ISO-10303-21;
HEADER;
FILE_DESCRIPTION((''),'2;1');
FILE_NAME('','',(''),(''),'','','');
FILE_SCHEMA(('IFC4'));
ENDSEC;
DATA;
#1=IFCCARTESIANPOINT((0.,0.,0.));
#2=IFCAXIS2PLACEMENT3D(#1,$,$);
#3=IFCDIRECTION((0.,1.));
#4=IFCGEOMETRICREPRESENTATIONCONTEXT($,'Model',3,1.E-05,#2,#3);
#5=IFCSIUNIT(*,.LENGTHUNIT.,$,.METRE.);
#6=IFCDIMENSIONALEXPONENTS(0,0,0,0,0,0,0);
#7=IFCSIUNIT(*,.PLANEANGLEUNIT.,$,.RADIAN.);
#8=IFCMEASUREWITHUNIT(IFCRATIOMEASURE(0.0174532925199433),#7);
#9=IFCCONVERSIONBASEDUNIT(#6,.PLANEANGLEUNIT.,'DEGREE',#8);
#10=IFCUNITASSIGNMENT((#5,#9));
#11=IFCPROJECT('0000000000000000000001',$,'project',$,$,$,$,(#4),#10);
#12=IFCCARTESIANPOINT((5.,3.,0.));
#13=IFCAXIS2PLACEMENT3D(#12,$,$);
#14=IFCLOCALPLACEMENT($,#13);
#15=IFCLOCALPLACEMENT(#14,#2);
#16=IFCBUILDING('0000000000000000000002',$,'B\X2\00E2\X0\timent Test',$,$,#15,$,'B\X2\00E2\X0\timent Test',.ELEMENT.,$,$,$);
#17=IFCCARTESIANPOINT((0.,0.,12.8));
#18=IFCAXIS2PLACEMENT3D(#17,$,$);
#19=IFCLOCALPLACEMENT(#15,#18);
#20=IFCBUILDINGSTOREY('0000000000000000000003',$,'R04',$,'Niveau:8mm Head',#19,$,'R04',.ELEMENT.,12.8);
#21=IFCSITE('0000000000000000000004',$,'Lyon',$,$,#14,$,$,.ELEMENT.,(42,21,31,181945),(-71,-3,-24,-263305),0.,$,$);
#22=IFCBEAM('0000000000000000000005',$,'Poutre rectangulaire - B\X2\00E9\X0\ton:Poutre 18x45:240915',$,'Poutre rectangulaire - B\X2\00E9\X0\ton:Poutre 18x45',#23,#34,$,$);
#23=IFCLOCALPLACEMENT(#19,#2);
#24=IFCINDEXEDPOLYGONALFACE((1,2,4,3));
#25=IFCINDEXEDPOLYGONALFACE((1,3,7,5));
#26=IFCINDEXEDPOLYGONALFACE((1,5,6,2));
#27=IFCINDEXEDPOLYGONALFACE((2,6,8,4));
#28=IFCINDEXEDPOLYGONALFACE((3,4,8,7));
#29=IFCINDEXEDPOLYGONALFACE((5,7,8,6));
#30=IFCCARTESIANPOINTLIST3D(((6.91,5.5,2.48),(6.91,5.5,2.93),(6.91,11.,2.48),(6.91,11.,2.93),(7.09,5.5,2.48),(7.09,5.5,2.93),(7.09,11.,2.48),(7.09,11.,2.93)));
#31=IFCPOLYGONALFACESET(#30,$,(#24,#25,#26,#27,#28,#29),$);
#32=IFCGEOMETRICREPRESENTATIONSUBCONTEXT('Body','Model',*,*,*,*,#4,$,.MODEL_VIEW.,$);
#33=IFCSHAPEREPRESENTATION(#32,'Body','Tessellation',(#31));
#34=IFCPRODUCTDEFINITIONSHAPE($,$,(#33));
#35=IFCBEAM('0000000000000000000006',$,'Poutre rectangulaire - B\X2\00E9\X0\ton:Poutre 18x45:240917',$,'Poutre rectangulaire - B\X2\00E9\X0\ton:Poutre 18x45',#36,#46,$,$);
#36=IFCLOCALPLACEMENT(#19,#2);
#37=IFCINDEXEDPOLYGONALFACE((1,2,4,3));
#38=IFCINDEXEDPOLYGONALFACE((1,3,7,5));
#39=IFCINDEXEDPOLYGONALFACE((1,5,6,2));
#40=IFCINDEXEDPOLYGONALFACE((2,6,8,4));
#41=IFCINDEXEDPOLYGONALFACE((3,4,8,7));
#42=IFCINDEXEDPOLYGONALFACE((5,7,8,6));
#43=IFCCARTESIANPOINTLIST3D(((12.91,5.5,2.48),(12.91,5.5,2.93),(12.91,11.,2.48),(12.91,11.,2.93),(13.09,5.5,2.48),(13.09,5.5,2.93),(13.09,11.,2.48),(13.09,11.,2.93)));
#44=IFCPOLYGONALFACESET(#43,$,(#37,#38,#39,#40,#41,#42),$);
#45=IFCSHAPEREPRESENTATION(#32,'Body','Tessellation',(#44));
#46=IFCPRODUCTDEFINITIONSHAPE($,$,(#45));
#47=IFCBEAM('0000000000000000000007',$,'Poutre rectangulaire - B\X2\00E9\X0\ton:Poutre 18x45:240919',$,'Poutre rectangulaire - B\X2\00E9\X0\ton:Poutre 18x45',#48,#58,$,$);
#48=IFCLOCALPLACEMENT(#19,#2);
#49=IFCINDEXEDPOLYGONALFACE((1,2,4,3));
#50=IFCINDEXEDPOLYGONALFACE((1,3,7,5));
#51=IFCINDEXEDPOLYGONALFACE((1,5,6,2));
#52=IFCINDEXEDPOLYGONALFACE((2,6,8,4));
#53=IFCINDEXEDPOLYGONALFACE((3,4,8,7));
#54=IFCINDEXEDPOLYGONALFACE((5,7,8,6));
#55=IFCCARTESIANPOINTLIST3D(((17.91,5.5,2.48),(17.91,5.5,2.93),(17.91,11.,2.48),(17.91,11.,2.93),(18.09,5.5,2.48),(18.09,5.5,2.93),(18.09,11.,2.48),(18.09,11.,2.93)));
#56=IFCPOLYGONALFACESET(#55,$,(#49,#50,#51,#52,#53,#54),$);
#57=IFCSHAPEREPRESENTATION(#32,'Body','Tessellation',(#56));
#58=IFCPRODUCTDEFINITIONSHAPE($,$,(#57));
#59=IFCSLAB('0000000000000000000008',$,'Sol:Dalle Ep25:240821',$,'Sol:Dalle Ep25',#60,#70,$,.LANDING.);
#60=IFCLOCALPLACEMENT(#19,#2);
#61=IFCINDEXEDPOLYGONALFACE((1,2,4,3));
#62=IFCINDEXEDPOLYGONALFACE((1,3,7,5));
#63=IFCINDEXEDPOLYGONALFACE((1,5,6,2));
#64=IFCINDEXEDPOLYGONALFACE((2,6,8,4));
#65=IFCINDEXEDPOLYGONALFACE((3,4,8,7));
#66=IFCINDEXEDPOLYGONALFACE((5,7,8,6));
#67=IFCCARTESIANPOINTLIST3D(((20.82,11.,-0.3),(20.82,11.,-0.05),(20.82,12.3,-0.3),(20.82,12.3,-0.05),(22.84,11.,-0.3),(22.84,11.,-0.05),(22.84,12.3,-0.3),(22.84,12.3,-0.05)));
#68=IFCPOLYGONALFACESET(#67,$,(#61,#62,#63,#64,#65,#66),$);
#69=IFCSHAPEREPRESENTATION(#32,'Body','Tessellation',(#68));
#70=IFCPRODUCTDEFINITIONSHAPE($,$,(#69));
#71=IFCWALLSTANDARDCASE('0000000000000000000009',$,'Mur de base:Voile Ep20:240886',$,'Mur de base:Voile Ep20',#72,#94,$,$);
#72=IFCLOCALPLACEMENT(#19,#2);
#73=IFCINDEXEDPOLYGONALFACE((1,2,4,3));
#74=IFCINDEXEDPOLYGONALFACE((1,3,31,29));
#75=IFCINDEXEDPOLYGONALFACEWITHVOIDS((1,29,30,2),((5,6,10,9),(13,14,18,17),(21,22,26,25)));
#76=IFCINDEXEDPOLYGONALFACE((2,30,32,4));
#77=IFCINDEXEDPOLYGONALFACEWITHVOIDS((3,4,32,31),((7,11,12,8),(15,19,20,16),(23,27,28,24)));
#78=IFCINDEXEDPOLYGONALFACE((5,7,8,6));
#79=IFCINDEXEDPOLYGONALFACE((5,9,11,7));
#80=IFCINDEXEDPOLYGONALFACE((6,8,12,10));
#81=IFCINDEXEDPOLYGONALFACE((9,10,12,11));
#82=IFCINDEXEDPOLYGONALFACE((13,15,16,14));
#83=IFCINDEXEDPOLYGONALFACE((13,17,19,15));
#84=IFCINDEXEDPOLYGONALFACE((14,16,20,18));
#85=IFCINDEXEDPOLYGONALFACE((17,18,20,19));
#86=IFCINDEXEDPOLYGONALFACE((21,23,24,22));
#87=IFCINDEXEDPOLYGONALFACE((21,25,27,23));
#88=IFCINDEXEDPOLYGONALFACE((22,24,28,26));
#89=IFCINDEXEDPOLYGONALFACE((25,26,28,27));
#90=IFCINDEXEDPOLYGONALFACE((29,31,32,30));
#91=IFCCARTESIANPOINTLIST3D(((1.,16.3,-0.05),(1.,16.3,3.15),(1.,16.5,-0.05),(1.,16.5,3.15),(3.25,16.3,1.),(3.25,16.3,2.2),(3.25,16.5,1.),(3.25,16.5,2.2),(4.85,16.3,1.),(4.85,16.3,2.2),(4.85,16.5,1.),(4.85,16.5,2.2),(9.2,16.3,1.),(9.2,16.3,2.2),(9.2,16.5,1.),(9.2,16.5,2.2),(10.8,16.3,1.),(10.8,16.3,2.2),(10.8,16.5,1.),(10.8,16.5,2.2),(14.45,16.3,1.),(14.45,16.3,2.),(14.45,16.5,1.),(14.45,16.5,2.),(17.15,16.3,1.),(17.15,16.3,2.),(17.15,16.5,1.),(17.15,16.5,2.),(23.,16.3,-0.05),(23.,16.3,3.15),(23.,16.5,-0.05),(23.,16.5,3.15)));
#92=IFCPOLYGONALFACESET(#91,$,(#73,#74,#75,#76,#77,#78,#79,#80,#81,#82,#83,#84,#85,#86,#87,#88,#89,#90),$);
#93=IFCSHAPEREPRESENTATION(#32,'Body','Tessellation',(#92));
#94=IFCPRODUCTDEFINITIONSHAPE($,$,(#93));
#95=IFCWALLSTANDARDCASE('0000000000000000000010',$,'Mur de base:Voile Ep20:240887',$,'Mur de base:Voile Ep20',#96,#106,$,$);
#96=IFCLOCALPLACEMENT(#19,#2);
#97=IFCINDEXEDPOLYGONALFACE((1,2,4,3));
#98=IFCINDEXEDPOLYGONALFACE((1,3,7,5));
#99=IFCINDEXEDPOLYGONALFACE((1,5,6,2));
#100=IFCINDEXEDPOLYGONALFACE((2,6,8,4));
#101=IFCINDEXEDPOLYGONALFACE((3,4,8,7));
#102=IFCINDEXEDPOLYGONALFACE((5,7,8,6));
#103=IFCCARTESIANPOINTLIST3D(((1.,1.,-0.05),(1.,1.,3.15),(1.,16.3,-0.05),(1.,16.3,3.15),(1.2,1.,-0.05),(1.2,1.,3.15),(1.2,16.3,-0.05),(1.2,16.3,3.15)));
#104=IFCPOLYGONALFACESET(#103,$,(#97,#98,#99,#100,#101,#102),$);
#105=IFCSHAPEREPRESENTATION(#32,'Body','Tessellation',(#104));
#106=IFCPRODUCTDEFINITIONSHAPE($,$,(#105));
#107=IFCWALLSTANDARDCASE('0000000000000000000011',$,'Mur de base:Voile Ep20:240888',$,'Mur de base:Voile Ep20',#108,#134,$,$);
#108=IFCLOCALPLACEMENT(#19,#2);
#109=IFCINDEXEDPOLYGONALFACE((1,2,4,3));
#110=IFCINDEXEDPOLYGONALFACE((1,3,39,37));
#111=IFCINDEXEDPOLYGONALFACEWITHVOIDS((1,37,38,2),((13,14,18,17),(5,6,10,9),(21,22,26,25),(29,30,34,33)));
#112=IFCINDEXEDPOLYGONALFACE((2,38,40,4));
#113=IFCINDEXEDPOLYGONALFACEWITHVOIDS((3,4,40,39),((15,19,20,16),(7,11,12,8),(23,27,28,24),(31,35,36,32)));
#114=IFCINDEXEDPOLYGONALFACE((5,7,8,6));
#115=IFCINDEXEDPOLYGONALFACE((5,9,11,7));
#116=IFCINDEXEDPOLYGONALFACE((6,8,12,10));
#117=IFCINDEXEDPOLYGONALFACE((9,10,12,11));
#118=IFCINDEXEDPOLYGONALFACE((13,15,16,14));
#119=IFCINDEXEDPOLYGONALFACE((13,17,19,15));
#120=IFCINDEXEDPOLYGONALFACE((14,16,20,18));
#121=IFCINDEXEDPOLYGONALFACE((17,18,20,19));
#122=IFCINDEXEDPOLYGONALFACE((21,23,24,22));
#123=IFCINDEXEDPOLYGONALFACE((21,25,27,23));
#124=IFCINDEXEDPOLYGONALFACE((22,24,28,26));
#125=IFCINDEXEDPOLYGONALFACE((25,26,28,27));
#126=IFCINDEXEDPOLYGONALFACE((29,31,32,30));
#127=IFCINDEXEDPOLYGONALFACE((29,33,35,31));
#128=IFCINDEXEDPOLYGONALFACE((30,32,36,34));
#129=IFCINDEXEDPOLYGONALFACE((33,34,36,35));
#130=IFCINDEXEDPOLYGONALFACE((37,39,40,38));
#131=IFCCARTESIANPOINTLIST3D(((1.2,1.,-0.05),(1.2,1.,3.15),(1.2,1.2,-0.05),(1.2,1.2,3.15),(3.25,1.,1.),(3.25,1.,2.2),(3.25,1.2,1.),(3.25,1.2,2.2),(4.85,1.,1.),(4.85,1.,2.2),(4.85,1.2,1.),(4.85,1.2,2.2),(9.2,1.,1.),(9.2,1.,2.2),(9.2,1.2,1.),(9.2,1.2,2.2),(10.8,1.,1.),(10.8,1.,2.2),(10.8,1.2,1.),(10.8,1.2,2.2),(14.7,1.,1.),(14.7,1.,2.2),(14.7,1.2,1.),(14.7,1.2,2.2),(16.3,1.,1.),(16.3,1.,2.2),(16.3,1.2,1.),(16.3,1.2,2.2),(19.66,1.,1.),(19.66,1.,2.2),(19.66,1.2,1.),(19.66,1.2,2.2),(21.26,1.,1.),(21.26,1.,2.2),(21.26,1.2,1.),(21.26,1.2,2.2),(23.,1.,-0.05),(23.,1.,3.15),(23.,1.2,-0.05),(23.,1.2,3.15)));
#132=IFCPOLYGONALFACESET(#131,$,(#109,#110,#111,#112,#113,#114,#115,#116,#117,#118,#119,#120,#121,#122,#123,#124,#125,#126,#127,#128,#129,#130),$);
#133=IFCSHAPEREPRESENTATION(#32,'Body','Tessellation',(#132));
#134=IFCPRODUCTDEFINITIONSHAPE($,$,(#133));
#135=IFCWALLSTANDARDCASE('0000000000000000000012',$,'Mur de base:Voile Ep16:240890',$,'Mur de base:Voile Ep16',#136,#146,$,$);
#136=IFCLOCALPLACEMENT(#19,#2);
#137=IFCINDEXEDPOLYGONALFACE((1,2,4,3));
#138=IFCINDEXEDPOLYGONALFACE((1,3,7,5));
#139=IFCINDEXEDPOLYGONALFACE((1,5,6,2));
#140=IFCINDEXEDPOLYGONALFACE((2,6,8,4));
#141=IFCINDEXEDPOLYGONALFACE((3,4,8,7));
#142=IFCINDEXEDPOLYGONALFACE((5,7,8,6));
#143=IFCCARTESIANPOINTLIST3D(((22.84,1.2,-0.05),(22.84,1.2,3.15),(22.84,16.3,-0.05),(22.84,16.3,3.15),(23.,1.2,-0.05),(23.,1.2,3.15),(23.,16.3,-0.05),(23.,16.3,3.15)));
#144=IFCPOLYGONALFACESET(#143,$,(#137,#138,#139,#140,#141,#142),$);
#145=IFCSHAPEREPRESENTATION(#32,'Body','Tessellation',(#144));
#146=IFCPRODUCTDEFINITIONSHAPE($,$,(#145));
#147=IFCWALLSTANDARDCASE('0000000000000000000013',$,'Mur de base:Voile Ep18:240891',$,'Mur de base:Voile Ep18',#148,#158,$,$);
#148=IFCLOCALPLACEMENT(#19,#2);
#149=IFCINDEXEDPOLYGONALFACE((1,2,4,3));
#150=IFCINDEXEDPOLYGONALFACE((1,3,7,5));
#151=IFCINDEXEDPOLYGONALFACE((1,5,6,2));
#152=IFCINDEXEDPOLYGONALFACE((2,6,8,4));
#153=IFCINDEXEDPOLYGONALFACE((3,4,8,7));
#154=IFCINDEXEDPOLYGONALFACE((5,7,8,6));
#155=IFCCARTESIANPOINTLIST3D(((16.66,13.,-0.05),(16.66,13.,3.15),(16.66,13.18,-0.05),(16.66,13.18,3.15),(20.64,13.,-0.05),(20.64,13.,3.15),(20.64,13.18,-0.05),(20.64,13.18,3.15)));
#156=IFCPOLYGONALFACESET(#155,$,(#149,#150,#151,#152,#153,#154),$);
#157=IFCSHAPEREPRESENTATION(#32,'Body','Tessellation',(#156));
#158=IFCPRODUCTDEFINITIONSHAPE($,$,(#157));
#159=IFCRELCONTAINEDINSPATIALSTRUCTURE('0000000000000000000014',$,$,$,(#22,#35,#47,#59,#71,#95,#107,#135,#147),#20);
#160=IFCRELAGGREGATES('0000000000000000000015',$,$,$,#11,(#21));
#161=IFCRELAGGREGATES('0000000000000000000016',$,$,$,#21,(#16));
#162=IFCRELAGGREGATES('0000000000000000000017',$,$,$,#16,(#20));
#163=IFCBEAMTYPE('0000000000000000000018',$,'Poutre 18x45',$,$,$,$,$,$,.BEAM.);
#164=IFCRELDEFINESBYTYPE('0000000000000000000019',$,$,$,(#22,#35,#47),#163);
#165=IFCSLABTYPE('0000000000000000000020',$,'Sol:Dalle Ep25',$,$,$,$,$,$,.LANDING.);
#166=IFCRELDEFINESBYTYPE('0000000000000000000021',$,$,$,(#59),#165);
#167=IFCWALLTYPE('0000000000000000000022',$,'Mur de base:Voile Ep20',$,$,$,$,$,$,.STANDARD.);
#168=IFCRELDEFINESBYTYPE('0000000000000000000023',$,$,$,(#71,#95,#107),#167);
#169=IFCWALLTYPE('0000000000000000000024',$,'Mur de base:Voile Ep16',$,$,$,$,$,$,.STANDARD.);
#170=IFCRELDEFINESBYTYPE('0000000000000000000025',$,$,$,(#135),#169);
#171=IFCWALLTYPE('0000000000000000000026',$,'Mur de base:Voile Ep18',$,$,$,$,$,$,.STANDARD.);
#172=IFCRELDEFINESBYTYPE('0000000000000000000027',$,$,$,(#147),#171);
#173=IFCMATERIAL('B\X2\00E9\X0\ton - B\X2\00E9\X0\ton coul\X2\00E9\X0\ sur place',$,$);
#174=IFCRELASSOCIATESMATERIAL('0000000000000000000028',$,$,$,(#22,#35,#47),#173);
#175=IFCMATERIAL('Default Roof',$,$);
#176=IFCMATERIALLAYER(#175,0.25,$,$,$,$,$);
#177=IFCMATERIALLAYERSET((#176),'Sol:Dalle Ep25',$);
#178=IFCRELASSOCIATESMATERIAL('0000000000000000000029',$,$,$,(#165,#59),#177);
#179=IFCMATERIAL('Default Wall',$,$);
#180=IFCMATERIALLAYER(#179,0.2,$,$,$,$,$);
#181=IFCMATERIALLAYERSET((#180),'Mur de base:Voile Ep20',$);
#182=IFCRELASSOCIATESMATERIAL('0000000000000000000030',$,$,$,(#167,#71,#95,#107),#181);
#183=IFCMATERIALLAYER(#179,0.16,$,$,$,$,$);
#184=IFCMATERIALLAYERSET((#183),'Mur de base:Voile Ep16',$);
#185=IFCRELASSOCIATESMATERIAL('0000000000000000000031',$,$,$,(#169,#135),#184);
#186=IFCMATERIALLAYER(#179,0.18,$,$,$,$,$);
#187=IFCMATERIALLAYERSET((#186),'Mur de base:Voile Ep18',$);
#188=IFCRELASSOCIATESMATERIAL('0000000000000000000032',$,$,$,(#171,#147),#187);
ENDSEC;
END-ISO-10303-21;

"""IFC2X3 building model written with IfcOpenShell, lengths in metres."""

from ifc_helpers import new_model, entity, si_unit, converted_unit, direction, frame, frame_2d, origin, origin_2d_with_axis, place, context, subcontext, project, spatial, rectangle, extrude, material, layer, layer_set, layer_usage, type_object, element, save


model = new_model("IFC2X3")

# Units and contexts
model_context = context("Model", 3, precision=1e-05, world=origin(), true_north=direction((0.0, 1.0)))
body_context = subcontext(model_context, "Body", "Model", "MODEL_VIEW")
ifc_project = project(units=[si_unit("LENGTHUNIT", "METRE"), converted_unit("PLANEANGLEUNIT", "DEGREE", entity("IfcRatioMeasure", 0.0174532925199433), si_unit("PLANEANGLEUNIT", "RADIAN"), dimensions=[0, 0, 0, 0, 0, 0, 0])], contexts=[model_context])

# Site, building, storey
site_placement = place(None, frame((5.0, 3.0, 0.0)))
site = spatial("IfcSite", under=ifc_project, at=site_placement, Name="Lyon", CompositionType="ELEMENT", RefLatitude=(42, 21, 31, 181945), RefLongitude=(-71, -3, -24, -263305), RefElevation=0.0)
building_placement = place(site_placement, origin())
building = spatial("IfcBuilding", under=site, at=building_placement, Name="Bâtiment Test", LongName="Bâtiment Test", CompositionType="ELEMENT")
storey_placement = place(building_placement, frame((0.0, 0.0, 12.8)))
storey = spatial("IfcBuildingStorey", under=building, at=storey_placement, Name="R04", ObjectType="Niveau:8mm Head", LongName="R04", CompositionType="ELEMENT", Elevation=12.8)

# Beams
ifc_material_1 = material(Name="Béton - Béton coulé sur place")
beam_type = type_object("IfcBeamType", Name="Poutre 18x45", PredefinedType="BEAM")
beam_1_placement = place(storey_placement, frame((7.0, 11.0, 2.93), z_axis=(0.0, 0.0, 1.0), x_axis=(0.0, -1.0, 0.0)))
element("IfcBeam", 1, at=beam_1_placement, inside=storey, type_object=beam_type, material=ifc_material_1, Name="Poutre rectangulaire - Béton:Poutre 18x45:240915", ObjectType="Poutre rectangulaire - Béton:Poutre 18x45", context=body_context, shape_type="SweptSolid", body=[
    extrude(rectangle(XDim=0.45, YDim=0.18, at=frame_2d((0.0, 0.0), x_axis=(1.0, 0.0))), frame((0.0, 0.0, -0.225), z_axis=(1.0, 0.0, 0.0), x_axis=(0.0, 0.0, -1.0)), (0.0, 0.0, 1.0), 5.5),
])
beam_2_placement = place(storey_placement, frame((13.0, 11.0, 2.93), z_axis=(0.0, 0.0, 1.0), x_axis=(0.0, -1.0, 0.0)))
element("IfcBeam", 2, at=beam_2_placement, inside=storey, type_object=beam_type, material=ifc_material_1, Name="Poutre rectangulaire - Béton:Poutre 18x45:240917", ObjectType="Poutre rectangulaire - Béton:Poutre 18x45", context=body_context, shape_type="SweptSolid", body=[
    extrude(rectangle(XDim=0.45, YDim=0.18, at=frame_2d((0.0, 0.0), x_axis=(1.0, 0.0))), frame((0.0, 0.0, -0.225), z_axis=(1.0, 0.0, 0.0), x_axis=(0.0, 0.0, -1.0)), (0.0, 0.0, 1.0), 5.5),
])
beam_3_placement = place(storey_placement, frame((18.0, 5.5, 2.93), z_axis=(0.0, 0.0, 1.0), x_axis=(0.0, 1.0, 0.0)))
element("IfcBeam", 3, at=beam_3_placement, inside=storey, type_object=beam_type, material=ifc_material_1, Name="Poutre rectangulaire - Béton:Poutre 18x45:240919", ObjectType="Poutre rectangulaire - Béton:Poutre 18x45", context=body_context, shape_type="SweptSolid", body=[
    extrude(rectangle(XDim=0.45, YDim=0.18, at=frame_2d((0.0, 0.0), x_axis=(1.0, 0.0))), frame((0.0, 0.0, -0.225), z_axis=(1.0, 0.0, 0.0), x_axis=(0.0, 0.0, -1.0)), (0.0, 0.0, 1.0), 5.5),
])

# Slab
ifc_material_2 = material(Name="Default Roof")
ifc_layer_1 = layer(ifc_material_2, 0.25)
ifc_layer_set_1 = layer_set([ifc_layer_1], Name="Sol:Dalle Ep25")
ifc_layer_usage_1 = layer_usage(ifc_layer_set_1, "AXIS3", "POSITIVE", 0.0)
slab_type_1 = type_object("IfcSlabType", Name="Sol:Dalle Ep25", PredefinedType="LANDING", material=ifc_layer_set_1)
slab_1_placement = place(storey_placement, origin())
element("IfcSlab", 4, at=slab_1_placement, inside=storey, type_object=slab_type_1, material=ifc_layer_usage_1, Name="Sol:Dalle Ep25:240821", ObjectType="Sol:Dalle Ep25", PredefinedType="LANDING", context=body_context, shape_type="SweptSolid", body=[
    extrude(rectangle(XDim=1.3, YDim=2.02, at=frame_2d((0.0, 0.0), x_axis=(1.0, 0.0))), frame((21.83, 11.65, -0.05), z_axis=(0.0, 0.0, -1.0), x_axis=(0.0, 1.0, 0.0)), (0.0, 0.0, 1.0), 0.25),
])

# Wall, openings
ifc_material_3 = material(Name="Default Wall")
ifc_layer_2 = layer(ifc_material_3, 0.2)
ifc_layer_set_2 = layer_set([ifc_layer_2], Name="Mur de base:Voile Ep20")
ifc_layer_usage_2 = layer_usage(ifc_layer_set_2, "AXIS2", "POSITIVE", -0.1)
wall_type_1 = type_object("IfcWallType", Name="Mur de base:Voile Ep20", PredefinedType="STANDARD", material=ifc_layer_set_2)
wall_1_placement = place(storey_placement, frame((23.0, 16.4, -0.05), z_axis=(0.0, 0.0, 1.0), x_axis=(-1.0, 0.0, 0.0)))
wall_1 = element("IfcWallStandardCase", 5, at=wall_1_placement, inside=storey, type_object=wall_type_1, material=ifc_layer_usage_2, Name="Mur de base:Voile Ep20:240886", ObjectType="Mur de base:Voile Ep20", context=body_context, shape_type="SweptSolid", body=[
    extrude(rectangle(XDim=22.0, YDim=0.2, at=frame_2d((11.0, 0.0), x_axis=(-1.0, 0.0))), origin(), (0.0, 0.0, 1.0), 3.2),
])
opening_1_placement = place(wall_1_placement, origin())
element("IfcOpeningElement", 6, at=opening_1_placement, cuts=wall_1, ObjectType="Opening", context=body_context, shape_type="SweptSolid", body=[
    extrude(rectangle(XDim=1.0, YDim=2.7, at=origin_2d_with_axis()), frame((7.2, -0.1, 1.55), z_axis=(0.0, 1.0, 0.0), x_axis=(0.0, 0.0, -1.0)), (0.0, 0.0, 1.0), 0.2),
])
opening_2_placement = place(wall_1_placement, origin())
element("IfcOpeningElement", 7, at=opening_2_placement, cuts=wall_1, ObjectType="Opening", context=body_context, shape_type="SweptSolid", body=[
    extrude(rectangle(XDim=1.2, YDim=1.6, at=frame_2d((0.0, 0.0), x_axis=(1.0, 0.0))), frame((13.0, -0.1, 1.65), z_axis=(0.0, 1.0, 0.0), x_axis=(0.0, 0.0, -1.0)), (0.0, 0.0, 1.0), 0.2),
])
opening_3_placement = place(wall_1_placement, origin())
element("IfcOpeningElement", 8, at=opening_3_placement, cuts=wall_1, ObjectType="Opening", context=body_context, shape_type="SweptSolid", body=[
    extrude(rectangle(XDim=1.2, YDim=1.6, at=frame_2d((0.0, 0.0), x_axis=(1.0, 0.0))), frame((18.95, -0.1, 1.65), z_axis=(0.0, 1.0, 0.0), x_axis=(0.0, 0.0, -1.0)), (0.0, 0.0, 1.0), 0.2),
])

# Wall
ifc_layer_usage_3 = layer_usage(ifc_layer_set_2, "AXIS2", "POSITIVE", -0.1)
wall_2_placement = place(storey_placement, frame((1.1, 16.3, -0.05), z_axis=(0.0, 0.0, 1.0), x_axis=(0.0, -1.0, 0.0)))
element("IfcWallStandardCase", 9, at=wall_2_placement, inside=storey, type_object=wall_type_1, material=ifc_layer_usage_3, Name="Mur de base:Voile Ep20:240887", ObjectType="Mur de base:Voile Ep20", context=body_context, shape_type="SweptSolid", body=[
    extrude(rectangle(XDim=15.3, YDim=0.2, at=frame_2d((7.65, 0.0), x_axis=(-1.0, 0.0))), origin(), (0.0, 0.0, 1.0), 3.2),
])

# Wall, openings
ifc_layer_usage_4 = layer_usage(ifc_layer_set_2, "AXIS2", "POSITIVE", -0.1)
wall_3_placement = place(storey_placement, frame((1.2, 1.1, -0.05)))
wall_3 = element("IfcWallStandardCase", 10, at=wall_3_placement, inside=storey, type_object=wall_type_1, material=ifc_layer_usage_4, Name="Mur de base:Voile Ep20:240888", ObjectType="Mur de base:Voile Ep20", context=body_context, shape_type="SweptSolid", body=[
    extrude(rectangle(XDim=21.8, YDim=0.2, at=frame_2d((10.9, 0.0), x_axis=(-1.0, 0.0))), origin(), (0.0, 0.0, 1.0), 3.2),
])
opening_4_placement = place(wall_3_placement, origin())
element("IfcOpeningElement", 11, at=opening_4_placement, cuts=wall_3, ObjectType="Opening", context=body_context, shape_type="SweptSolid", body=[
    extrude(rectangle(XDim=1.2, YDim=1.6, at=frame_2d((0.0, 0.0), x_axis=(0.0, 1.0))), frame((2.85, -0.1, 1.65), z_axis=(0.0, 1.0, 0.0), x_axis=(1.0, 0.0, 0.0)), (0.0, 0.0, 1.0), 0.2),
])
opening_5_placement = place(wall_3_placement, origin())
element("IfcOpeningElement", 12, at=opening_5_placement, cuts=wall_3, ObjectType="Opening", context=body_context, shape_type="SweptSolid", body=[
    extrude(rectangle(XDim=1.2, YDim=1.6, at=frame_2d((0.0, 0.0), x_axis=(1.0, 0.0))), frame((8.8, -0.1, 1.65), z_axis=(0.0, 1.0, 0.0), x_axis=(0.0, 0.0, -1.0)), (0.0, 0.0, 1.0), 0.2),
])
opening_6_placement = place(wall_3_placement, origin())
element("IfcOpeningElement", 13, at=opening_6_placement, cuts=wall_3, ObjectType="Opening", context=body_context, shape_type="SweptSolid", body=[
    extrude(rectangle(XDim=1.2, YDim=1.6, at=frame_2d((0.0, 0.0), x_axis=(0.0, 1.0))), frame((14.3, -0.1, 1.65), z_axis=(0.0, 1.0, 0.0), x_axis=(1.0, 0.0, 0.0)), (0.0, 0.0, 1.0), 0.2),
])
opening_7_placement = place(wall_3_placement, origin())
element("IfcOpeningElement", 14, at=opening_7_placement, cuts=wall_3, ObjectType="Opening", context=body_context, shape_type="SweptSolid", body=[
    extrude(rectangle(XDim=1.2, YDim=1.6, at=frame_2d((0.0, 0.0), x_axis=(1.0, 0.0))), frame((19.26, -0.1, 1.65), z_axis=(0.0, 1.0, 0.0), x_axis=(0.0, 0.0, -1.0)), (0.0, 0.0, 1.0), 0.2),
])

# Walls
ifc_layer_3 = layer(ifc_material_3, 0.16)
ifc_layer_set_3 = layer_set([ifc_layer_3], Name="Mur de base:Voile Ep16")
ifc_layer_usage_5 = layer_usage(ifc_layer_set_3, "AXIS2", "NEGATIVE", 0.08)
wall_type_2 = type_object("IfcWallType", Name="Mur de base:Voile Ep16", PredefinedType="STANDARD", material=ifc_layer_set_3)
wall_4_placement = place(storey_placement, frame((22.92, 16.3, -0.05), z_axis=(0.0, 0.0, 1.0), x_axis=(0.0, -1.0, 0.0)))
element("IfcWallStandardCase", 15, at=wall_4_placement, inside=storey, type_object=wall_type_2, material=ifc_layer_usage_5, Name="Mur de base:Voile Ep16:240890", ObjectType="Mur de base:Voile Ep16", context=body_context, shape_type="SweptSolid", body=[
    extrude(rectangle(XDim=15.1, YDim=0.16, at=frame_2d((7.55, 0.0), x_axis=(-1.0, 0.0))), origin(), (0.0, 0.0, 1.0), 3.2),
])
ifc_layer_4 = layer(ifc_material_3, 0.18)
ifc_layer_set_4 = layer_set([ifc_layer_4], Name="Mur de base:Voile Ep18")
ifc_layer_usage_6 = layer_usage(ifc_layer_set_4, "AXIS2", "NEGATIVE", 0.09)
wall_type_3 = type_object("IfcWallType", Name="Mur de base:Voile Ep18", PredefinedType="STANDARD", material=ifc_layer_set_4)
wall_5_placement = place(storey_placement, frame((20.64, 13.09, -0.05), z_axis=(0.0, 0.0, 1.0), x_axis=(-1.0, 0.0, 0.0)))
element("IfcWallStandardCase", 16, at=wall_5_placement, inside=storey, type_object=wall_type_3, material=ifc_layer_usage_6, Name="Mur de base:Voile Ep18:240891", ObjectType="Mur de base:Voile Ep18", context=body_context, shape_type="SweptSolid", body=[
    extrude(rectangle(XDim=3.98, YDim=0.18, at=frame_2d((1.99, 0.0), x_axis=(-1.0, 0.0))), origin(), (0.0, 0.0, 1.0), 3.2),
])

save(model, "model.ifc")
